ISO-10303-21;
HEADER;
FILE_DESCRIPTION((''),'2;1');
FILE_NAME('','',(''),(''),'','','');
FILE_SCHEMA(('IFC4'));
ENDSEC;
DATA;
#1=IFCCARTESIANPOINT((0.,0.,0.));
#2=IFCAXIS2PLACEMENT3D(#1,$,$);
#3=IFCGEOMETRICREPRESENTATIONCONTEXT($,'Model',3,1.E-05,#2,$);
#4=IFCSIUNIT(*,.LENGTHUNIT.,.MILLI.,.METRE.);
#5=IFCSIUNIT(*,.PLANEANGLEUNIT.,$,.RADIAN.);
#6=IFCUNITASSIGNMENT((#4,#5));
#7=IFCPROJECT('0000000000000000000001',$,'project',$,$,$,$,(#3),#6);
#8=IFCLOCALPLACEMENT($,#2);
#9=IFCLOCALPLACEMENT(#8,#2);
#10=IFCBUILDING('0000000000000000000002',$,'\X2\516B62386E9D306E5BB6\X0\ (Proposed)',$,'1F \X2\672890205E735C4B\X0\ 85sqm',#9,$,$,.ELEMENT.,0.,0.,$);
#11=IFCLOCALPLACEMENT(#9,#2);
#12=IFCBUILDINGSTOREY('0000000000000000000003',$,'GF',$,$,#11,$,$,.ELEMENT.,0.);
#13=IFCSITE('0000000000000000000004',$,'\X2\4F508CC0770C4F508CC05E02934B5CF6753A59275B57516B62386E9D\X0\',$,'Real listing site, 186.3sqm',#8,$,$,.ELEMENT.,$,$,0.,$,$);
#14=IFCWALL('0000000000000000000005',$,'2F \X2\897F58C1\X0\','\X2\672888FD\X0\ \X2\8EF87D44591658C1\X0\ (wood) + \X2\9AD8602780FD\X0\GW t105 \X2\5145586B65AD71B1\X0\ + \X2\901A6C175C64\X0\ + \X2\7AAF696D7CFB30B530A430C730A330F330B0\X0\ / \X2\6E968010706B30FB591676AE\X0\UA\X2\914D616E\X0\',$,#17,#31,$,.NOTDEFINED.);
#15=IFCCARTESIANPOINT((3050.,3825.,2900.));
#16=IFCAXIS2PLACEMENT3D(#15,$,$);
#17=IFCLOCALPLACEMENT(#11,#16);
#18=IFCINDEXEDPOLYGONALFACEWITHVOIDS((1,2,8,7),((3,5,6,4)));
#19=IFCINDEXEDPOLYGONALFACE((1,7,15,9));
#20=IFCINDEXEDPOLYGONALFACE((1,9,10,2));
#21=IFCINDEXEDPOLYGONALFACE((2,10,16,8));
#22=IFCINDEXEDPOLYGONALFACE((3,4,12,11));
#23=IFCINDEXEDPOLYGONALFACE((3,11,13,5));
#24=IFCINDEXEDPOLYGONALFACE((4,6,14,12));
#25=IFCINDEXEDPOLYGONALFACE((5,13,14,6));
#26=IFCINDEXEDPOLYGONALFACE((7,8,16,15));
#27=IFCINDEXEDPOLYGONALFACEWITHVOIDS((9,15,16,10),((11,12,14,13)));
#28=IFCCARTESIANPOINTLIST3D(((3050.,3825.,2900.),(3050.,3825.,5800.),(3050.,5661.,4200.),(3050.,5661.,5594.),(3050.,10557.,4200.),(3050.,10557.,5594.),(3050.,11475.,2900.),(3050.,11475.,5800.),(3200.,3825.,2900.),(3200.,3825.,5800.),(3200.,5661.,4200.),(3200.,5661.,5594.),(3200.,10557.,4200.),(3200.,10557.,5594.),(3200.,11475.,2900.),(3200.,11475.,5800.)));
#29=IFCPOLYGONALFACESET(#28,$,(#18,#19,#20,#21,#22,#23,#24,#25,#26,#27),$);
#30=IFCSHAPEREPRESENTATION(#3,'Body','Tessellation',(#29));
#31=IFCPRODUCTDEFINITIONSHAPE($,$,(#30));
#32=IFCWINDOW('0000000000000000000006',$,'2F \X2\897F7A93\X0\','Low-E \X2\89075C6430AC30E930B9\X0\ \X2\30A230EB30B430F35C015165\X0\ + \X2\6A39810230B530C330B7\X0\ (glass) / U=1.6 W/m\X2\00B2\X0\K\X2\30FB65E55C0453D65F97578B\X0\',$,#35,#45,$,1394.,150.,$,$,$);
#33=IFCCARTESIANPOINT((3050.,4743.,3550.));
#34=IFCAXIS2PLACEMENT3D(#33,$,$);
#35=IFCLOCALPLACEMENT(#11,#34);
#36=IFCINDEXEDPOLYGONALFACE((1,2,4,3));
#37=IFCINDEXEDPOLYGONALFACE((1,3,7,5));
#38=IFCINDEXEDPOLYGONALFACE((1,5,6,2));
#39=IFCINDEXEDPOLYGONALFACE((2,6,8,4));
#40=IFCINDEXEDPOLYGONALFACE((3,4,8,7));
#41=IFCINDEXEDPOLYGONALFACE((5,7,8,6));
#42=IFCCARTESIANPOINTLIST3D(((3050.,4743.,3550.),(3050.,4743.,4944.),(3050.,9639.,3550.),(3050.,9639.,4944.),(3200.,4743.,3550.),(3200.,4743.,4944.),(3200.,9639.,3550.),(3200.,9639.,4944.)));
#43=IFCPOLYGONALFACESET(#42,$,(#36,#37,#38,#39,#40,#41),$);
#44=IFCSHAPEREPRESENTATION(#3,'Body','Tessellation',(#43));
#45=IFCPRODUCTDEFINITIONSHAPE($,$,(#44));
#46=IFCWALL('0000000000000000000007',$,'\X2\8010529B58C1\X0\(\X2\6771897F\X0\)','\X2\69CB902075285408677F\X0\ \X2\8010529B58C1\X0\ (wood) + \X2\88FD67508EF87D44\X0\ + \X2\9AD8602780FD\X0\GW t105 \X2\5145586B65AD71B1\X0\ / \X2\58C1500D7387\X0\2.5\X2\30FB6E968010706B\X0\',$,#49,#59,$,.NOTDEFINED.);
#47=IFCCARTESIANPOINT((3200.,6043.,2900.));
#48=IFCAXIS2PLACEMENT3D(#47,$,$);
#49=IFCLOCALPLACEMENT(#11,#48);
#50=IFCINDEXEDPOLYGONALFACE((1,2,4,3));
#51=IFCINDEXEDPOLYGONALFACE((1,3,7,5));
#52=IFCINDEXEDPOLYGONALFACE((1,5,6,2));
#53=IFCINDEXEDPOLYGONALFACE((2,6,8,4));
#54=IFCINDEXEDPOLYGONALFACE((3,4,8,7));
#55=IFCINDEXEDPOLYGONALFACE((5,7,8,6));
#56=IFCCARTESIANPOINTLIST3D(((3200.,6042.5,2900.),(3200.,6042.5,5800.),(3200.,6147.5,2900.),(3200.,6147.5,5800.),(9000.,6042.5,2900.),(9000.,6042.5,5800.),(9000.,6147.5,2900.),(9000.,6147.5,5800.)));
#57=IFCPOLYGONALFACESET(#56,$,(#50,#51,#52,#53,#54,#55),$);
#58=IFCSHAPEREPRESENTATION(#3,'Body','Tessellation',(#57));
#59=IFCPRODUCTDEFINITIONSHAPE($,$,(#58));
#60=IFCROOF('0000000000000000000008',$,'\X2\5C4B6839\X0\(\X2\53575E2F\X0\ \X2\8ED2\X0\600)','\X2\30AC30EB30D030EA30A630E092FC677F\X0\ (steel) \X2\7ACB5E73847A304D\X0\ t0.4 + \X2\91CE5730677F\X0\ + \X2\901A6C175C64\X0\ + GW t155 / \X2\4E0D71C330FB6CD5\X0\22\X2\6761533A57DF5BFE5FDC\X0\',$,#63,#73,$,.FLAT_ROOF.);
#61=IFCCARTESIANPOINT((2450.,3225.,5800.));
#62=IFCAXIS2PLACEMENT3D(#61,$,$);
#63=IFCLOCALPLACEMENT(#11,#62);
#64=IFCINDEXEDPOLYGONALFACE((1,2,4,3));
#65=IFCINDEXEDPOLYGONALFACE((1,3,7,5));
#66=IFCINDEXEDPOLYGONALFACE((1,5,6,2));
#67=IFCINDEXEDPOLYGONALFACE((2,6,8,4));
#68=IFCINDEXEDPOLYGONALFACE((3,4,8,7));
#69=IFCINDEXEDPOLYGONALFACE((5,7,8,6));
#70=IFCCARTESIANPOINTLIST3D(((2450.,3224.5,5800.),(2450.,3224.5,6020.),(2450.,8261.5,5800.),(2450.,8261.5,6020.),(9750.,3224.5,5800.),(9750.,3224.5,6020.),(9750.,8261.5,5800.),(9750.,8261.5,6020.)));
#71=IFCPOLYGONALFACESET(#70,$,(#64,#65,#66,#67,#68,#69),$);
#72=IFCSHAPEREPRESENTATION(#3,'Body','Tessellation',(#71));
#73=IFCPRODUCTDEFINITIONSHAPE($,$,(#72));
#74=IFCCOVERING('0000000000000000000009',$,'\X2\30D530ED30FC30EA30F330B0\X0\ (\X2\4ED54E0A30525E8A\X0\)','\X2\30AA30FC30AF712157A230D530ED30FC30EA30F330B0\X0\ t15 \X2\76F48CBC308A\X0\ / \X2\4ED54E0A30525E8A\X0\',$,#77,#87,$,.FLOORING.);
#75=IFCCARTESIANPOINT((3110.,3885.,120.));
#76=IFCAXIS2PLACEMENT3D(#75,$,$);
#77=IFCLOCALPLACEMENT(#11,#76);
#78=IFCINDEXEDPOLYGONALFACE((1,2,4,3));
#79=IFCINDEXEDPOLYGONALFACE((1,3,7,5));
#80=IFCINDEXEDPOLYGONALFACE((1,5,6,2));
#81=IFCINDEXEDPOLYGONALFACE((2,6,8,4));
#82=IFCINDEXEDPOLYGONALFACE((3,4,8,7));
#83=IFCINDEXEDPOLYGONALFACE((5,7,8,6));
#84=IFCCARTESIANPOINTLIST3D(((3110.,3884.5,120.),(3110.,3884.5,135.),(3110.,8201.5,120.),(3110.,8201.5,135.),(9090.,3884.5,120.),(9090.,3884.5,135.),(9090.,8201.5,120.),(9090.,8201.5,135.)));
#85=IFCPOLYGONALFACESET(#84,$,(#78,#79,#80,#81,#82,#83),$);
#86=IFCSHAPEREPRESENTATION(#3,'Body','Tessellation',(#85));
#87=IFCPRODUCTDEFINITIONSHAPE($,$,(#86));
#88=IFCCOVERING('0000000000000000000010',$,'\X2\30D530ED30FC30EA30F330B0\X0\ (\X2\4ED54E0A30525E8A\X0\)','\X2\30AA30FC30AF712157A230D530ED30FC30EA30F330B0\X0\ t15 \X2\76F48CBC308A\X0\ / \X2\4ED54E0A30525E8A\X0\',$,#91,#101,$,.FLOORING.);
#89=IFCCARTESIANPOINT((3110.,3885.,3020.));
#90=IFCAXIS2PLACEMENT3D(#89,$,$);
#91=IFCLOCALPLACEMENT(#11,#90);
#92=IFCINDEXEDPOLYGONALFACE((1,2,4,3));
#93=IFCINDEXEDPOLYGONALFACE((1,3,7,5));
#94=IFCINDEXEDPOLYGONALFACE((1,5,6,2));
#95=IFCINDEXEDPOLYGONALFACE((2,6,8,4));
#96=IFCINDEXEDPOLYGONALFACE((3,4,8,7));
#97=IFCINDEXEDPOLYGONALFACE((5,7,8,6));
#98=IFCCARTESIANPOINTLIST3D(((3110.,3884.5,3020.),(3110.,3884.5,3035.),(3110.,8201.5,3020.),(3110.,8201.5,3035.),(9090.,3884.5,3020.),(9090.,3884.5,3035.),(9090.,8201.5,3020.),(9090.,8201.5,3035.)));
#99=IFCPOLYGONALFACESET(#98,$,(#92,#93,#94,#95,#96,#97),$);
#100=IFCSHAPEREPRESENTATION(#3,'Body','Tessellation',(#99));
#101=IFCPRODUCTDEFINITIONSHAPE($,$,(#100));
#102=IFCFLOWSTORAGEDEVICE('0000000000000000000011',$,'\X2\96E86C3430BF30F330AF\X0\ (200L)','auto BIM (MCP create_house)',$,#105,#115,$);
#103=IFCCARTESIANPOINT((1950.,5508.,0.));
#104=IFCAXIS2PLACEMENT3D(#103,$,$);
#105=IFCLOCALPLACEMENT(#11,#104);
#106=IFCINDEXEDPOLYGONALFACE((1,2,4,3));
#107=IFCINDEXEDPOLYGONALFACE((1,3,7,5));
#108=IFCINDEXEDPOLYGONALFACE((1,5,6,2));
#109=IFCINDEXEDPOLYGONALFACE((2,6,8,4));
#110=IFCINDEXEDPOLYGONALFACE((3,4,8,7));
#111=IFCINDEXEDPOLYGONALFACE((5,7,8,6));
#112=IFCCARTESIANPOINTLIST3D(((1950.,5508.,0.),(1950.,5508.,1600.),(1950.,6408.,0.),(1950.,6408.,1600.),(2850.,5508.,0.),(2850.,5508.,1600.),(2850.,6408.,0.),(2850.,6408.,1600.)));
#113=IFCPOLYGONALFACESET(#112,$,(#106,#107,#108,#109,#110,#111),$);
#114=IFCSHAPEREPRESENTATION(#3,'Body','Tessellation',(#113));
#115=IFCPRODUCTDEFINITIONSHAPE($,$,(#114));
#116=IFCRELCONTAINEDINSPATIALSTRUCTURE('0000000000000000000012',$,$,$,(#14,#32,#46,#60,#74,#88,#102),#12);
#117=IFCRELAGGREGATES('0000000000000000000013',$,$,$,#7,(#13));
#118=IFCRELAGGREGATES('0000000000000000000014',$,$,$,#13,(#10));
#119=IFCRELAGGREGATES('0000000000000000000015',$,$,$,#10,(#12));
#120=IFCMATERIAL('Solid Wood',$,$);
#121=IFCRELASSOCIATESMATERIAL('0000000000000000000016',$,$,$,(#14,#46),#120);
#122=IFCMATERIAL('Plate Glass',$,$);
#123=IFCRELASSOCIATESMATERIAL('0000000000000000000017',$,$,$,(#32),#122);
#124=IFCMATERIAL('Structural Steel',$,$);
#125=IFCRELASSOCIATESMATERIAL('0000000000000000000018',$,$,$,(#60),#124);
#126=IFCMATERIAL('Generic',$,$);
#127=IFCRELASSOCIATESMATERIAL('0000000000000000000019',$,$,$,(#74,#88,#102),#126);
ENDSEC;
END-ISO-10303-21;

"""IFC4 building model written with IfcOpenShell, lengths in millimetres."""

from ifc_helpers import new_model, si_unit, frame, frame_2d, origin, place, context, project, spatial, rectangle, extrude, material, element, fill, save


model = new_model("IFC4")

# Units and contexts
model_context = context("Model", 3, precision=1e-05, world=origin())
ifc_project = project(units=[si_unit("LENGTHUNIT", "METRE", prefix="MILLI"), si_unit("PLANEANGLEUNIT", "RADIAN")], contexts=[model_context])

# Site, building, storey
site_placement = place(None, origin())
site = spatial("IfcSite", under=ifc_project, at=site_placement, Name="佐賀県佐賀市鍋島町大字八戸溝", ObjectType="Real listing site, 186.3sqm", CompositionType="ELEMENT", RefElevation=0.0)
building_placement = place(site_placement, origin())
building = spatial("IfcBuilding", under=site, at=building_placement, Name="八戸溝の家 (Proposed)", ObjectType="1F 木造平屋 85sqm", CompositionType="ELEMENT", ElevationOfRefHeight=0.0, ElevationOfTerrain=0.0)
storey_placement = place(building_placement, origin())
storey = spatial("IfcBuildingStorey", under=building, at=storey_placement, Name="GF", CompositionType="ELEMENT", Elevation=0.0)

# Shared definitions
ifc_material_1 = material(Name="Solid Wood")
ifc_material_2 = material(Name="Generic")

# Shared definitions
ifc_material_3 = material(Name="Plate Glass")

# Wall, opening, window
wall_1_placement = place(storey_placement, frame((3050.0, 3825.0, 2900.0)))
wall_1 = element("IfcWall", 1, at=wall_1_placement, inside=storey, material=ifc_material_1, Name="2F 西壁", Description="木製 軸組外壁 (wood) + 高性能GW t105 充填断熱 + 通気層 + 窯業系サイディング / 準耐火・外皮UA配慮", PredefinedType="NOTDEFINED", context=model_context, shape_type="SweptSolid", body=[
    extrude(rectangle(XDim=150.0, YDim=7650.0, at=frame_2d((75.0, 3825.0))), frame((3050.0, 3825.0, 2900.0)), (0.0, 0.0, 1.0), 2900.0),
])
opening_1_placement = place(storey_placement, frame((3050.0, 4743.0, 3550.0)))
opening_1 = element("IfcOpeningElement", 2, at=opening_1_placement, cuts=wall_1, PredefinedType="NOTDEFINED", context=model_context, shape_type="SweptSolid", body=[
    extrude(rectangle(XDim=150.0, YDim=4896.0, at=frame_2d((75.0, 2448.0))), frame((3050.0, 4743.0, 3550.0)), (0.0, 0.0, 1.0), 1394.0),
])
window_1_placement = place(storey_placement, frame((3050.0, 4743.0, 3550.0)))
window_1 = element("IfcWindow", 3, at=window_1_placement, inside=storey, material=ifc_material_3, Name="2F 西窓", Description="Low-E 複層ガラス アルゴン封入 + 樹脂サッシ (glass) / U=1.6 W/m²K・日射取得型", OverallHeight=1394.0, OverallWidth=150.0, context=model_context, shape_type="SweptSolid", body=[
    extrude(rectangle(XDim=150.0, YDim=4896.0, at=frame_2d((75.0, 2448.0))), frame((3050.0, 4743.0, 3550.0)), (0.0, 0.0, 1.0), 1394.0),
])
fill(opening_1, window_1)

# Wall
wall_2_placement = place(storey_placement, frame((3200.0, 6043.0, 2900.0)))
element("IfcWall", 4, at=wall_2_placement, inside=storey, material=ifc_material_1, Name="耐力壁(東西)", Description="構造用合板 耐力壁 (wood) + 製材軸組 + 高性能GW t105 充填断熱 / 壁倍率2.5・準耐火", PredefinedType="NOTDEFINED", context=model_context, shape_type="SweptSolid", body=[
    extrude(rectangle(XDim=5800.0, YDim=105.0, at=frame_2d((2900.0, 52.0))), frame((3200.0, 6043.0, 2900.0)), (0.0, 0.0, 1.0), 2900.0),
])

# Roof
ifc_material_4 = material(Name="Structural Steel")
for number, where, name in (
    (5, (2450.0, 3225.0, 5800.0), "屋根(南帯 軒600)"),
):
    element("IfcRoof", number, at=place(storey_placement, frame(where)), inside=storey, material=ifc_material_4, Name=name, Description="ガルバリウム鋼板 (steel) 立平葺き t0.4 + 野地板 + 通気層 + GW t155 / 不燃・法22条区域対応", PredefinedType="FLAT_ROOF", context=model_context, shape_type="SweptSolid", body=[
        extrude(rectangle(XDim=7300.0, YDim=5037.0, at=frame_2d((3650.0, 2518.0))), frame((2450.0, 3225.0, 5800.0)), (0.0, 0.0, 1.0), 220.0),
    ])

# Coverings
covering_1_placement = place(storey_placement, frame((3110.0, 3885.0, 120.0)))
element("IfcCovering", 6, at=covering_1_placement, inside=storey, material=ifc_material_2, Name="フローリング (仕上げ床)", Description="オーク無垢フローリング t15 直貼り / 仕上げ床", PredefinedType="FLOORING", context=model_context, shape_type="SweptSolid", body=[
    extrude(rectangle(XDim=5980.0, YDim=4317.0, at=frame_2d((2990.0, 2158.0))), frame((3110.0, 3885.0, 120.0)), (0.0, 0.0, 1.0), 15.0),
])
covering_2_placement = place(storey_placement, frame((3110.0, 3885.0, 3020.0)))
element("IfcCovering", 7, at=covering_2_placement, inside=storey, material=ifc_material_2, Name="フローリング (仕上げ床)", Description="オーク無垢フローリング t15 直貼り / 仕上げ床", PredefinedType="FLOORING", context=model_context, shape_type="SweptSolid", body=[
    extrude(rectangle(XDim=5980.0, YDim=4317.0, at=frame_2d((2990.0, 2158.0))), frame((3110.0, 3885.0, 3020.0)), (0.0, 0.0, 1.0), 15.0),
])

# Flow storage device
flow_storage_device_placement = place(storey_placement, frame((1950.0, 5508.0, 0.0)))
element("IfcFlowStorageDevice", 8, at=flow_storage_device_placement, inside=storey, material=ifc_material_2, Name="雨水タンク (200L)", Description="auto BIM (MCP create_house)", context=model_context, shape_type="SweptSolid", body=[
    extrude(rectangle(XDim=900.0, YDim=900.0, at=frame_2d((450.0, 450.0))), frame((1950.0, 5508.0, 0.0)), (0.0, 0.0, 1.0), 1600.0),
])

save(model, "model.ifc")
